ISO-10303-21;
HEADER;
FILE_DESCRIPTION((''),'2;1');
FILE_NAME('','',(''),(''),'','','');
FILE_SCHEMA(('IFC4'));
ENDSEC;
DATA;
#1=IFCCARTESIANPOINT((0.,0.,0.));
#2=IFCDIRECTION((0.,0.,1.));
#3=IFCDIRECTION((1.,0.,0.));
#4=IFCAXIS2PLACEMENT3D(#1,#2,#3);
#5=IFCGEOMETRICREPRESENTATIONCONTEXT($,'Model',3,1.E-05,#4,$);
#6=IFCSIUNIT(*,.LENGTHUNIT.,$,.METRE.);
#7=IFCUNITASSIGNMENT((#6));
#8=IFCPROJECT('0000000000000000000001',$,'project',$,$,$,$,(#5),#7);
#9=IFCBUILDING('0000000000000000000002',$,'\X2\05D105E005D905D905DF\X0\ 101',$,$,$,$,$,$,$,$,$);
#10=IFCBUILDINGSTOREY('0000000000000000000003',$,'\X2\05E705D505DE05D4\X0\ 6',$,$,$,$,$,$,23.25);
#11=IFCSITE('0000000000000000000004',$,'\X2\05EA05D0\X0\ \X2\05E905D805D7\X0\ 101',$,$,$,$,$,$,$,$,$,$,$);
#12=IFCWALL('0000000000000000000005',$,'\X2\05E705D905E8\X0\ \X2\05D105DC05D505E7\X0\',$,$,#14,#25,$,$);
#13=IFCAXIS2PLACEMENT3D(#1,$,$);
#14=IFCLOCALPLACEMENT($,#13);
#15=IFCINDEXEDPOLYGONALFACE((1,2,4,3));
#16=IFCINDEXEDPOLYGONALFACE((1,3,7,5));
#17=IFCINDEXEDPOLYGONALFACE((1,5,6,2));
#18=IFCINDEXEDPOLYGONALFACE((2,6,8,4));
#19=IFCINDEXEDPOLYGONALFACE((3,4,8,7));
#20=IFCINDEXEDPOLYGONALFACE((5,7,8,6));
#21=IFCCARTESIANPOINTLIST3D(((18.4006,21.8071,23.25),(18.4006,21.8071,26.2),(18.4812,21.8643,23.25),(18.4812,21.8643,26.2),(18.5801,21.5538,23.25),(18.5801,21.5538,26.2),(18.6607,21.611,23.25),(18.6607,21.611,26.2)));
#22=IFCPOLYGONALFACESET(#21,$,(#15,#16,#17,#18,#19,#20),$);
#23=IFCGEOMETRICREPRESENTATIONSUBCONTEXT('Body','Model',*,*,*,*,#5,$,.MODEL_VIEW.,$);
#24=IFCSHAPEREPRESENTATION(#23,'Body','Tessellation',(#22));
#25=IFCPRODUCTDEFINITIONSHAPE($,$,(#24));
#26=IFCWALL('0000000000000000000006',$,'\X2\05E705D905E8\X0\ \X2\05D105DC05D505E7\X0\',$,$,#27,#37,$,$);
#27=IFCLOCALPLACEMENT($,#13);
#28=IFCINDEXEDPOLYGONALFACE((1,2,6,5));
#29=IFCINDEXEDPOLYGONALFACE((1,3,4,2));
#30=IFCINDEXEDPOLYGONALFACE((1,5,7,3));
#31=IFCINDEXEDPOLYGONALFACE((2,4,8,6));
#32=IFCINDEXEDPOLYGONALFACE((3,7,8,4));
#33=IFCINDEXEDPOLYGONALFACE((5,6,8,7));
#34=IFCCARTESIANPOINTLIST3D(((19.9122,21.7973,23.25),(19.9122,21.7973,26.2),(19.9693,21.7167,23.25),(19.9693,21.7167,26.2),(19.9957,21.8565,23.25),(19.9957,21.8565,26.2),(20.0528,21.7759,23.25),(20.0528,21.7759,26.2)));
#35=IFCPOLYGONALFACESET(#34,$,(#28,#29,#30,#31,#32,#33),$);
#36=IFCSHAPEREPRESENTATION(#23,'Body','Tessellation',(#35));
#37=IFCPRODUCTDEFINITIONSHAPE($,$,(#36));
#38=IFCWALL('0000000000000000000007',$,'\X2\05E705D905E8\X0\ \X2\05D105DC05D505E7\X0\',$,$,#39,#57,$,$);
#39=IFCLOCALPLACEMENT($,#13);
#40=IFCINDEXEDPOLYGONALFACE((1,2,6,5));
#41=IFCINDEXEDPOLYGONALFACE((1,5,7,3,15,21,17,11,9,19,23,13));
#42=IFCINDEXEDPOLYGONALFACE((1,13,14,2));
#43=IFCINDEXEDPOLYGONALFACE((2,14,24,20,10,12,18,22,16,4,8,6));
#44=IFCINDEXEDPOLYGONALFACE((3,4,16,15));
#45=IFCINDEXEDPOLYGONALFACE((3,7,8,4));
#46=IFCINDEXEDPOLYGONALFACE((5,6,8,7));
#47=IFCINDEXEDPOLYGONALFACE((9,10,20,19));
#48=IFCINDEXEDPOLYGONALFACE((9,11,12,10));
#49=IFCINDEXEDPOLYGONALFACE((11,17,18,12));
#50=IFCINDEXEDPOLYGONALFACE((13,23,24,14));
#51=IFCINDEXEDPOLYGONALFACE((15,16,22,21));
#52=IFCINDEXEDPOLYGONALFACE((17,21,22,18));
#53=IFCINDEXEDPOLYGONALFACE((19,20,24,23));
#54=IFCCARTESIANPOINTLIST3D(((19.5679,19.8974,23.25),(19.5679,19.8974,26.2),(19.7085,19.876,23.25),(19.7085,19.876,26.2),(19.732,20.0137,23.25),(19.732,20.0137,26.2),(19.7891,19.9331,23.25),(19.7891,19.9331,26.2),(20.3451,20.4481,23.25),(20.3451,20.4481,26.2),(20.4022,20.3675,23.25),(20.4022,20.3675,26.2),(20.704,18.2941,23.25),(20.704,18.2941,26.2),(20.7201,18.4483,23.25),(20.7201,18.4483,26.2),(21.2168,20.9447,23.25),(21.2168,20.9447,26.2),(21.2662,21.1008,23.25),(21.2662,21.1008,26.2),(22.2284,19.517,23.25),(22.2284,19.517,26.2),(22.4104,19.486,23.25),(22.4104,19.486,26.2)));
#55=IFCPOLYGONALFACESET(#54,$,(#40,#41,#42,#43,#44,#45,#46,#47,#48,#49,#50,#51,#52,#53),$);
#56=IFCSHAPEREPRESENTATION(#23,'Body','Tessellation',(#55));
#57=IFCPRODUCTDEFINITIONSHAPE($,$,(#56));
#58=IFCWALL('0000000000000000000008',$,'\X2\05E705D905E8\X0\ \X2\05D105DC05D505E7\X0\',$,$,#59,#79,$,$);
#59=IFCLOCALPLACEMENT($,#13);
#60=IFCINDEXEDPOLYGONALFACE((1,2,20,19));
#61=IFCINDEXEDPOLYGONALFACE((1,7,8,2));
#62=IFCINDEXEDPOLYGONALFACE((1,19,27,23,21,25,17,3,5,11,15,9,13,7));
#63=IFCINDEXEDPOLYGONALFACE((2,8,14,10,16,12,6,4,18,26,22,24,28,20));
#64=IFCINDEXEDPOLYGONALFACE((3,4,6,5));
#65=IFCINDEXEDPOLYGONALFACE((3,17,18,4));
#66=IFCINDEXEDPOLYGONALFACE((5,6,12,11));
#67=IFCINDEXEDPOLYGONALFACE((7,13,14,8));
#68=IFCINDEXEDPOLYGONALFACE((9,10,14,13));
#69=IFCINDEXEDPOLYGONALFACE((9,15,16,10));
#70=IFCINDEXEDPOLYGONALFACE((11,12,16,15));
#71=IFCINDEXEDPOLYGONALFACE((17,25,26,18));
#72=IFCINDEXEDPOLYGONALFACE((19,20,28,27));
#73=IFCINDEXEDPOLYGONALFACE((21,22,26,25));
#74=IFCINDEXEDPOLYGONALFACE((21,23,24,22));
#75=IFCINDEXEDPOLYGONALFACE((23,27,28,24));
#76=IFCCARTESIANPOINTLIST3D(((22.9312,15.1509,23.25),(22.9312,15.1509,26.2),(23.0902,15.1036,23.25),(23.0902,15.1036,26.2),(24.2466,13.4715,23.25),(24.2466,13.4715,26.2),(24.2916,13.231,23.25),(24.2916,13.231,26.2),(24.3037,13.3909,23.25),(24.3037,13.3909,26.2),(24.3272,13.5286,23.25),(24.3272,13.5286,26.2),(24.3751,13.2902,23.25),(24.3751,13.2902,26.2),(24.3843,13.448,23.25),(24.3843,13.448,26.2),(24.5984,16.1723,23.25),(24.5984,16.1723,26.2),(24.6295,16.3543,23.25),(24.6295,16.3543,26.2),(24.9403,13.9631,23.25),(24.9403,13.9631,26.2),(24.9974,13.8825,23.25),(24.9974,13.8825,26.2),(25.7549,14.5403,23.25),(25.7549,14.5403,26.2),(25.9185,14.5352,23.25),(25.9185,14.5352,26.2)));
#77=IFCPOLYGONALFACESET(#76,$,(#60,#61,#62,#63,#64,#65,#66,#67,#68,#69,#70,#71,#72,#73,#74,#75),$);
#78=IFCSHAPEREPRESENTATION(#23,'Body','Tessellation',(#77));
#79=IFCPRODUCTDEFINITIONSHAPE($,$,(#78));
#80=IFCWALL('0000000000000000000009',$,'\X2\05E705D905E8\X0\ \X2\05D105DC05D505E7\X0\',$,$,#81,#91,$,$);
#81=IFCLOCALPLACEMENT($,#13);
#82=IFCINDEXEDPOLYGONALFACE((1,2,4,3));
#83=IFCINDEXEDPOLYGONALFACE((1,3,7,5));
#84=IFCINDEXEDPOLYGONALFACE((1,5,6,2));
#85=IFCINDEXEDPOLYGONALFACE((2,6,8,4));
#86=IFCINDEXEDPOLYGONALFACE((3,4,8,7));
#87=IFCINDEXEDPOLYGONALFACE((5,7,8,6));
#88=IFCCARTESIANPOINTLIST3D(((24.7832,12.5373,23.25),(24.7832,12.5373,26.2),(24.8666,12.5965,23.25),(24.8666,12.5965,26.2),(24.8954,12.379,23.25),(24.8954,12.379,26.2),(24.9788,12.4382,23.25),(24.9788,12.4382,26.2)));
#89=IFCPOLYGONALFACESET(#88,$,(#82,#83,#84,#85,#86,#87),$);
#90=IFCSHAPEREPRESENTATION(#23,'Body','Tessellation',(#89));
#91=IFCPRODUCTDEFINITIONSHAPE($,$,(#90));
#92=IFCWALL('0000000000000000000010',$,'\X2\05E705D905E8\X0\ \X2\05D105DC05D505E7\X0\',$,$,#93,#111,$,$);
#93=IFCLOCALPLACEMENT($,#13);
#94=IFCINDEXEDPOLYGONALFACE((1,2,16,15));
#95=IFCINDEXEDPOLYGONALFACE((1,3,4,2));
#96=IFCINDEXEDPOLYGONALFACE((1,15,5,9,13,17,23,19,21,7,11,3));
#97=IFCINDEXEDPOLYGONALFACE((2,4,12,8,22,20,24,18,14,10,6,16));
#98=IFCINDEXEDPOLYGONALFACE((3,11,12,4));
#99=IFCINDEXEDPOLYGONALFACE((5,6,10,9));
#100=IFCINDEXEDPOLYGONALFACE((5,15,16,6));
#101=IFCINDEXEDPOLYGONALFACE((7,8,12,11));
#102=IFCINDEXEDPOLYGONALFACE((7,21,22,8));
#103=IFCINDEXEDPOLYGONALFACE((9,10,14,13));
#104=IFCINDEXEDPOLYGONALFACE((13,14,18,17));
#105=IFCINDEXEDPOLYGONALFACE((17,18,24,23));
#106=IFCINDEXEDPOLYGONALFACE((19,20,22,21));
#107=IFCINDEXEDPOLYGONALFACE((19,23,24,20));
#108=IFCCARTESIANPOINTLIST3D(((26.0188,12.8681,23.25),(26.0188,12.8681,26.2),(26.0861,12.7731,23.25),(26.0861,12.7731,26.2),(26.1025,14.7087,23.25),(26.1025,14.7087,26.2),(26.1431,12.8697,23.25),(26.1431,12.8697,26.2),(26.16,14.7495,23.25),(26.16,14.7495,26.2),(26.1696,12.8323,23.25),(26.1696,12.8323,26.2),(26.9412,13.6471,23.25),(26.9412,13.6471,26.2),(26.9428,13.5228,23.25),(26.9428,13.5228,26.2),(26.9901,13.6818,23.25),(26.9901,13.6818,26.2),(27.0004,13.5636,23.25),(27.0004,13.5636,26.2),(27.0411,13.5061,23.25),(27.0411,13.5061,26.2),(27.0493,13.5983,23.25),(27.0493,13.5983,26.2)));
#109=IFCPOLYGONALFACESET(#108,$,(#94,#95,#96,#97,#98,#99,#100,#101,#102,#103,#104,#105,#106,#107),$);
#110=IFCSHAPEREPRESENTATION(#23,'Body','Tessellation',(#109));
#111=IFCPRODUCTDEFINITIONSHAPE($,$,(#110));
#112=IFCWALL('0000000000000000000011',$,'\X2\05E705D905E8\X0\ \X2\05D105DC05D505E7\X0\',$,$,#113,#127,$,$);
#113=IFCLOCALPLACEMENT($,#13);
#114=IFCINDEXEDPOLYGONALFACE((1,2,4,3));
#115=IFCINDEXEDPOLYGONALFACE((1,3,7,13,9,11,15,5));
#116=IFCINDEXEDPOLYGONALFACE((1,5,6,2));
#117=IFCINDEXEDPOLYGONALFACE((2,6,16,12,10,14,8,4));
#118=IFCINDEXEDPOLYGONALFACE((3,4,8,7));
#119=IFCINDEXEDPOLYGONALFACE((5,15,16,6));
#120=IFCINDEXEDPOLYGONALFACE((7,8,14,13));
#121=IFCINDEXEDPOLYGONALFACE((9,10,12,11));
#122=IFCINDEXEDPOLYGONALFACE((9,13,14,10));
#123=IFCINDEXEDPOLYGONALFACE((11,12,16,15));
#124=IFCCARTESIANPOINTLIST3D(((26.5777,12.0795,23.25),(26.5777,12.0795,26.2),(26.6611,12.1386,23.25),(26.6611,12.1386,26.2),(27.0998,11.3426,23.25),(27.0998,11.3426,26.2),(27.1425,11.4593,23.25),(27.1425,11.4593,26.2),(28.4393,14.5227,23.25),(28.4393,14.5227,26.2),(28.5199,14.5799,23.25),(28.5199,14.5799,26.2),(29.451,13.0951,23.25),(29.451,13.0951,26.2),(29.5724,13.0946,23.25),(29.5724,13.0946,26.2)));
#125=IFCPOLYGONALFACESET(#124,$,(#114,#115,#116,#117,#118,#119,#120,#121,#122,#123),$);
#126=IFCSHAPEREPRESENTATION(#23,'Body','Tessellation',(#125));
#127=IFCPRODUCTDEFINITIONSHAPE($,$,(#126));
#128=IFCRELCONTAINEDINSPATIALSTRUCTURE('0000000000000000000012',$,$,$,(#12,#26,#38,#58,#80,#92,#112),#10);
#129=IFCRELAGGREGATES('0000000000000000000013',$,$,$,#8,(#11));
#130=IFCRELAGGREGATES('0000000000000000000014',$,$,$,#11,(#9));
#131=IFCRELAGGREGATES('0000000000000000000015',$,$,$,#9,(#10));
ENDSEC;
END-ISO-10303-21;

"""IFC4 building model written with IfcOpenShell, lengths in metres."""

from ifc_helpers import new_model, si_unit, frame, origin_with_axes, context, subcontext, project, spatial, polyline, outline, extrude, element, save


model = new_model("IFC4")

# Units and contexts
model_context = context("Model", 3, precision=1e-05, world=origin_with_axes())
body_context = subcontext(model_context, "Body", "Model", "MODEL_VIEW")
ifc_project = project(units=[si_unit("LENGTHUNIT", "METRE")], contexts=[model_context])

# Site, building, storey
site = spatial("IfcSite", under=ifc_project, Name="תא שטח 101")
building = spatial("IfcBuilding", under=site, Name="בניין 101")
storey = spatial("IfcBuildingStorey", under=building, Name="קומה 6", Elevation=23.25)

# Walls
element("IfcWall", 1, inside=storey, Name="קיר בלוק", context=body_context, shape_type="SweptSolid", body=[
    extrude(outline(polyline([(18.4006, 21.8071), (18.5801, 21.5538), (18.6607, 21.611), (18.4812, 21.8643), (18.4006, 21.8071)])), frame((0.0, 0.0, 23.25)), (0.0, 0.0, 1.0), 2.95),
])
element("IfcWall", 2, inside=storey, Name="קיר בלוק", context=body_context, shape_type="SweptSolid", body=[
    extrude(outline(polyline([(19.9957, 21.8565), (19.9122, 21.7973), (19.9693, 21.7167), (20.0528, 21.7759), (19.9957, 21.8565)])), frame((0.0, 0.0, 23.25)), (0.0, 0.0, 1.0), 2.95),
])
element("IfcWall", 3, inside=storey, Name="קיר בלוק", context=body_context, shape_type="SweptSolid", body=[
    extrude(outline(polyline([(20.704, 18.2941), (22.4104, 19.486), (21.2662, 21.1008), (20.3451, 20.4481), (20.4022, 20.3675), (21.2168, 20.9447), (22.2284, 19.517), (20.7201, 18.4483), (19.7085, 19.876), (19.7891, 19.9331), (19.732, 20.0137), (19.5679, 19.8974), (20.704, 18.2941)])), frame((0.0, 0.0, 23.25)), (0.0, 0.0, 1.0), 2.95),
])
element("IfcWall", 4, inside=storey, Name="קיר בלוק", context=body_context, shape_type="SweptSolid", body=[
    extrude(outline(polyline([(24.3751, 13.2902), (24.3037, 13.3909), (24.3843, 13.448), (24.3272, 13.5286), (24.2466, 13.4715), (23.0902, 15.1036), (24.5984, 16.1723), (25.7549, 14.5403), (24.9403, 13.9631), (24.9974, 13.8825), (25.9185, 14.5352), (24.6295, 16.3543), (22.9312, 15.1509), (24.2916, 13.231), (24.3751, 13.2902)])), frame((0.0, 0.0, 23.25)), (0.0, 0.0, 1.0), 2.95),
])
element("IfcWall", 5, inside=storey, Name="קיר בלוק", context=body_context, shape_type="SweptSolid", body=[
    extrude(outline(polyline([(24.8666, 12.5965), (24.7832, 12.5373), (24.8954, 12.379), (24.9788, 12.4382), (24.8666, 12.5965)])), frame((0.0, 0.0, 23.25)), (0.0, 0.0, 1.0), 2.95),
])
element("IfcWall", 6, inside=storey, Name="קיר בלוק", context=body_context, shape_type="SweptSolid", body=[
    extrude(outline(polyline([(26.1431, 12.8697), (27.0411, 13.5061), (27.0004, 13.5636), (27.0493, 13.5983), (26.9901, 13.6818), (26.9412, 13.6471), (26.16, 14.7495), (26.1025, 14.7087), (26.9428, 13.5228), (26.0188, 12.8681), (26.0861, 12.7731), (26.1696, 12.8323), (26.1431, 12.8697)])), frame((0.0, 0.0, 23.25)), (0.0, 0.0, 1.0), 2.95),
])
element("IfcWall", 7, inside=storey, Name="קיר בלוק", context=body_context, shape_type="SweptSolid", body=[
    extrude(outline(polyline([(27.0998, 11.3426), (29.5724, 13.0946), (28.5199, 14.5799), (28.4393, 14.5227), (29.451, 13.0951), (27.1425, 11.4593), (26.6611, 12.1386), (26.5777, 12.0795), (27.0998, 11.3426)])), frame((0.0, 0.0, 23.25)), (0.0, 0.0, 1.0), 2.95),
])

save(model, "model.ifc")
